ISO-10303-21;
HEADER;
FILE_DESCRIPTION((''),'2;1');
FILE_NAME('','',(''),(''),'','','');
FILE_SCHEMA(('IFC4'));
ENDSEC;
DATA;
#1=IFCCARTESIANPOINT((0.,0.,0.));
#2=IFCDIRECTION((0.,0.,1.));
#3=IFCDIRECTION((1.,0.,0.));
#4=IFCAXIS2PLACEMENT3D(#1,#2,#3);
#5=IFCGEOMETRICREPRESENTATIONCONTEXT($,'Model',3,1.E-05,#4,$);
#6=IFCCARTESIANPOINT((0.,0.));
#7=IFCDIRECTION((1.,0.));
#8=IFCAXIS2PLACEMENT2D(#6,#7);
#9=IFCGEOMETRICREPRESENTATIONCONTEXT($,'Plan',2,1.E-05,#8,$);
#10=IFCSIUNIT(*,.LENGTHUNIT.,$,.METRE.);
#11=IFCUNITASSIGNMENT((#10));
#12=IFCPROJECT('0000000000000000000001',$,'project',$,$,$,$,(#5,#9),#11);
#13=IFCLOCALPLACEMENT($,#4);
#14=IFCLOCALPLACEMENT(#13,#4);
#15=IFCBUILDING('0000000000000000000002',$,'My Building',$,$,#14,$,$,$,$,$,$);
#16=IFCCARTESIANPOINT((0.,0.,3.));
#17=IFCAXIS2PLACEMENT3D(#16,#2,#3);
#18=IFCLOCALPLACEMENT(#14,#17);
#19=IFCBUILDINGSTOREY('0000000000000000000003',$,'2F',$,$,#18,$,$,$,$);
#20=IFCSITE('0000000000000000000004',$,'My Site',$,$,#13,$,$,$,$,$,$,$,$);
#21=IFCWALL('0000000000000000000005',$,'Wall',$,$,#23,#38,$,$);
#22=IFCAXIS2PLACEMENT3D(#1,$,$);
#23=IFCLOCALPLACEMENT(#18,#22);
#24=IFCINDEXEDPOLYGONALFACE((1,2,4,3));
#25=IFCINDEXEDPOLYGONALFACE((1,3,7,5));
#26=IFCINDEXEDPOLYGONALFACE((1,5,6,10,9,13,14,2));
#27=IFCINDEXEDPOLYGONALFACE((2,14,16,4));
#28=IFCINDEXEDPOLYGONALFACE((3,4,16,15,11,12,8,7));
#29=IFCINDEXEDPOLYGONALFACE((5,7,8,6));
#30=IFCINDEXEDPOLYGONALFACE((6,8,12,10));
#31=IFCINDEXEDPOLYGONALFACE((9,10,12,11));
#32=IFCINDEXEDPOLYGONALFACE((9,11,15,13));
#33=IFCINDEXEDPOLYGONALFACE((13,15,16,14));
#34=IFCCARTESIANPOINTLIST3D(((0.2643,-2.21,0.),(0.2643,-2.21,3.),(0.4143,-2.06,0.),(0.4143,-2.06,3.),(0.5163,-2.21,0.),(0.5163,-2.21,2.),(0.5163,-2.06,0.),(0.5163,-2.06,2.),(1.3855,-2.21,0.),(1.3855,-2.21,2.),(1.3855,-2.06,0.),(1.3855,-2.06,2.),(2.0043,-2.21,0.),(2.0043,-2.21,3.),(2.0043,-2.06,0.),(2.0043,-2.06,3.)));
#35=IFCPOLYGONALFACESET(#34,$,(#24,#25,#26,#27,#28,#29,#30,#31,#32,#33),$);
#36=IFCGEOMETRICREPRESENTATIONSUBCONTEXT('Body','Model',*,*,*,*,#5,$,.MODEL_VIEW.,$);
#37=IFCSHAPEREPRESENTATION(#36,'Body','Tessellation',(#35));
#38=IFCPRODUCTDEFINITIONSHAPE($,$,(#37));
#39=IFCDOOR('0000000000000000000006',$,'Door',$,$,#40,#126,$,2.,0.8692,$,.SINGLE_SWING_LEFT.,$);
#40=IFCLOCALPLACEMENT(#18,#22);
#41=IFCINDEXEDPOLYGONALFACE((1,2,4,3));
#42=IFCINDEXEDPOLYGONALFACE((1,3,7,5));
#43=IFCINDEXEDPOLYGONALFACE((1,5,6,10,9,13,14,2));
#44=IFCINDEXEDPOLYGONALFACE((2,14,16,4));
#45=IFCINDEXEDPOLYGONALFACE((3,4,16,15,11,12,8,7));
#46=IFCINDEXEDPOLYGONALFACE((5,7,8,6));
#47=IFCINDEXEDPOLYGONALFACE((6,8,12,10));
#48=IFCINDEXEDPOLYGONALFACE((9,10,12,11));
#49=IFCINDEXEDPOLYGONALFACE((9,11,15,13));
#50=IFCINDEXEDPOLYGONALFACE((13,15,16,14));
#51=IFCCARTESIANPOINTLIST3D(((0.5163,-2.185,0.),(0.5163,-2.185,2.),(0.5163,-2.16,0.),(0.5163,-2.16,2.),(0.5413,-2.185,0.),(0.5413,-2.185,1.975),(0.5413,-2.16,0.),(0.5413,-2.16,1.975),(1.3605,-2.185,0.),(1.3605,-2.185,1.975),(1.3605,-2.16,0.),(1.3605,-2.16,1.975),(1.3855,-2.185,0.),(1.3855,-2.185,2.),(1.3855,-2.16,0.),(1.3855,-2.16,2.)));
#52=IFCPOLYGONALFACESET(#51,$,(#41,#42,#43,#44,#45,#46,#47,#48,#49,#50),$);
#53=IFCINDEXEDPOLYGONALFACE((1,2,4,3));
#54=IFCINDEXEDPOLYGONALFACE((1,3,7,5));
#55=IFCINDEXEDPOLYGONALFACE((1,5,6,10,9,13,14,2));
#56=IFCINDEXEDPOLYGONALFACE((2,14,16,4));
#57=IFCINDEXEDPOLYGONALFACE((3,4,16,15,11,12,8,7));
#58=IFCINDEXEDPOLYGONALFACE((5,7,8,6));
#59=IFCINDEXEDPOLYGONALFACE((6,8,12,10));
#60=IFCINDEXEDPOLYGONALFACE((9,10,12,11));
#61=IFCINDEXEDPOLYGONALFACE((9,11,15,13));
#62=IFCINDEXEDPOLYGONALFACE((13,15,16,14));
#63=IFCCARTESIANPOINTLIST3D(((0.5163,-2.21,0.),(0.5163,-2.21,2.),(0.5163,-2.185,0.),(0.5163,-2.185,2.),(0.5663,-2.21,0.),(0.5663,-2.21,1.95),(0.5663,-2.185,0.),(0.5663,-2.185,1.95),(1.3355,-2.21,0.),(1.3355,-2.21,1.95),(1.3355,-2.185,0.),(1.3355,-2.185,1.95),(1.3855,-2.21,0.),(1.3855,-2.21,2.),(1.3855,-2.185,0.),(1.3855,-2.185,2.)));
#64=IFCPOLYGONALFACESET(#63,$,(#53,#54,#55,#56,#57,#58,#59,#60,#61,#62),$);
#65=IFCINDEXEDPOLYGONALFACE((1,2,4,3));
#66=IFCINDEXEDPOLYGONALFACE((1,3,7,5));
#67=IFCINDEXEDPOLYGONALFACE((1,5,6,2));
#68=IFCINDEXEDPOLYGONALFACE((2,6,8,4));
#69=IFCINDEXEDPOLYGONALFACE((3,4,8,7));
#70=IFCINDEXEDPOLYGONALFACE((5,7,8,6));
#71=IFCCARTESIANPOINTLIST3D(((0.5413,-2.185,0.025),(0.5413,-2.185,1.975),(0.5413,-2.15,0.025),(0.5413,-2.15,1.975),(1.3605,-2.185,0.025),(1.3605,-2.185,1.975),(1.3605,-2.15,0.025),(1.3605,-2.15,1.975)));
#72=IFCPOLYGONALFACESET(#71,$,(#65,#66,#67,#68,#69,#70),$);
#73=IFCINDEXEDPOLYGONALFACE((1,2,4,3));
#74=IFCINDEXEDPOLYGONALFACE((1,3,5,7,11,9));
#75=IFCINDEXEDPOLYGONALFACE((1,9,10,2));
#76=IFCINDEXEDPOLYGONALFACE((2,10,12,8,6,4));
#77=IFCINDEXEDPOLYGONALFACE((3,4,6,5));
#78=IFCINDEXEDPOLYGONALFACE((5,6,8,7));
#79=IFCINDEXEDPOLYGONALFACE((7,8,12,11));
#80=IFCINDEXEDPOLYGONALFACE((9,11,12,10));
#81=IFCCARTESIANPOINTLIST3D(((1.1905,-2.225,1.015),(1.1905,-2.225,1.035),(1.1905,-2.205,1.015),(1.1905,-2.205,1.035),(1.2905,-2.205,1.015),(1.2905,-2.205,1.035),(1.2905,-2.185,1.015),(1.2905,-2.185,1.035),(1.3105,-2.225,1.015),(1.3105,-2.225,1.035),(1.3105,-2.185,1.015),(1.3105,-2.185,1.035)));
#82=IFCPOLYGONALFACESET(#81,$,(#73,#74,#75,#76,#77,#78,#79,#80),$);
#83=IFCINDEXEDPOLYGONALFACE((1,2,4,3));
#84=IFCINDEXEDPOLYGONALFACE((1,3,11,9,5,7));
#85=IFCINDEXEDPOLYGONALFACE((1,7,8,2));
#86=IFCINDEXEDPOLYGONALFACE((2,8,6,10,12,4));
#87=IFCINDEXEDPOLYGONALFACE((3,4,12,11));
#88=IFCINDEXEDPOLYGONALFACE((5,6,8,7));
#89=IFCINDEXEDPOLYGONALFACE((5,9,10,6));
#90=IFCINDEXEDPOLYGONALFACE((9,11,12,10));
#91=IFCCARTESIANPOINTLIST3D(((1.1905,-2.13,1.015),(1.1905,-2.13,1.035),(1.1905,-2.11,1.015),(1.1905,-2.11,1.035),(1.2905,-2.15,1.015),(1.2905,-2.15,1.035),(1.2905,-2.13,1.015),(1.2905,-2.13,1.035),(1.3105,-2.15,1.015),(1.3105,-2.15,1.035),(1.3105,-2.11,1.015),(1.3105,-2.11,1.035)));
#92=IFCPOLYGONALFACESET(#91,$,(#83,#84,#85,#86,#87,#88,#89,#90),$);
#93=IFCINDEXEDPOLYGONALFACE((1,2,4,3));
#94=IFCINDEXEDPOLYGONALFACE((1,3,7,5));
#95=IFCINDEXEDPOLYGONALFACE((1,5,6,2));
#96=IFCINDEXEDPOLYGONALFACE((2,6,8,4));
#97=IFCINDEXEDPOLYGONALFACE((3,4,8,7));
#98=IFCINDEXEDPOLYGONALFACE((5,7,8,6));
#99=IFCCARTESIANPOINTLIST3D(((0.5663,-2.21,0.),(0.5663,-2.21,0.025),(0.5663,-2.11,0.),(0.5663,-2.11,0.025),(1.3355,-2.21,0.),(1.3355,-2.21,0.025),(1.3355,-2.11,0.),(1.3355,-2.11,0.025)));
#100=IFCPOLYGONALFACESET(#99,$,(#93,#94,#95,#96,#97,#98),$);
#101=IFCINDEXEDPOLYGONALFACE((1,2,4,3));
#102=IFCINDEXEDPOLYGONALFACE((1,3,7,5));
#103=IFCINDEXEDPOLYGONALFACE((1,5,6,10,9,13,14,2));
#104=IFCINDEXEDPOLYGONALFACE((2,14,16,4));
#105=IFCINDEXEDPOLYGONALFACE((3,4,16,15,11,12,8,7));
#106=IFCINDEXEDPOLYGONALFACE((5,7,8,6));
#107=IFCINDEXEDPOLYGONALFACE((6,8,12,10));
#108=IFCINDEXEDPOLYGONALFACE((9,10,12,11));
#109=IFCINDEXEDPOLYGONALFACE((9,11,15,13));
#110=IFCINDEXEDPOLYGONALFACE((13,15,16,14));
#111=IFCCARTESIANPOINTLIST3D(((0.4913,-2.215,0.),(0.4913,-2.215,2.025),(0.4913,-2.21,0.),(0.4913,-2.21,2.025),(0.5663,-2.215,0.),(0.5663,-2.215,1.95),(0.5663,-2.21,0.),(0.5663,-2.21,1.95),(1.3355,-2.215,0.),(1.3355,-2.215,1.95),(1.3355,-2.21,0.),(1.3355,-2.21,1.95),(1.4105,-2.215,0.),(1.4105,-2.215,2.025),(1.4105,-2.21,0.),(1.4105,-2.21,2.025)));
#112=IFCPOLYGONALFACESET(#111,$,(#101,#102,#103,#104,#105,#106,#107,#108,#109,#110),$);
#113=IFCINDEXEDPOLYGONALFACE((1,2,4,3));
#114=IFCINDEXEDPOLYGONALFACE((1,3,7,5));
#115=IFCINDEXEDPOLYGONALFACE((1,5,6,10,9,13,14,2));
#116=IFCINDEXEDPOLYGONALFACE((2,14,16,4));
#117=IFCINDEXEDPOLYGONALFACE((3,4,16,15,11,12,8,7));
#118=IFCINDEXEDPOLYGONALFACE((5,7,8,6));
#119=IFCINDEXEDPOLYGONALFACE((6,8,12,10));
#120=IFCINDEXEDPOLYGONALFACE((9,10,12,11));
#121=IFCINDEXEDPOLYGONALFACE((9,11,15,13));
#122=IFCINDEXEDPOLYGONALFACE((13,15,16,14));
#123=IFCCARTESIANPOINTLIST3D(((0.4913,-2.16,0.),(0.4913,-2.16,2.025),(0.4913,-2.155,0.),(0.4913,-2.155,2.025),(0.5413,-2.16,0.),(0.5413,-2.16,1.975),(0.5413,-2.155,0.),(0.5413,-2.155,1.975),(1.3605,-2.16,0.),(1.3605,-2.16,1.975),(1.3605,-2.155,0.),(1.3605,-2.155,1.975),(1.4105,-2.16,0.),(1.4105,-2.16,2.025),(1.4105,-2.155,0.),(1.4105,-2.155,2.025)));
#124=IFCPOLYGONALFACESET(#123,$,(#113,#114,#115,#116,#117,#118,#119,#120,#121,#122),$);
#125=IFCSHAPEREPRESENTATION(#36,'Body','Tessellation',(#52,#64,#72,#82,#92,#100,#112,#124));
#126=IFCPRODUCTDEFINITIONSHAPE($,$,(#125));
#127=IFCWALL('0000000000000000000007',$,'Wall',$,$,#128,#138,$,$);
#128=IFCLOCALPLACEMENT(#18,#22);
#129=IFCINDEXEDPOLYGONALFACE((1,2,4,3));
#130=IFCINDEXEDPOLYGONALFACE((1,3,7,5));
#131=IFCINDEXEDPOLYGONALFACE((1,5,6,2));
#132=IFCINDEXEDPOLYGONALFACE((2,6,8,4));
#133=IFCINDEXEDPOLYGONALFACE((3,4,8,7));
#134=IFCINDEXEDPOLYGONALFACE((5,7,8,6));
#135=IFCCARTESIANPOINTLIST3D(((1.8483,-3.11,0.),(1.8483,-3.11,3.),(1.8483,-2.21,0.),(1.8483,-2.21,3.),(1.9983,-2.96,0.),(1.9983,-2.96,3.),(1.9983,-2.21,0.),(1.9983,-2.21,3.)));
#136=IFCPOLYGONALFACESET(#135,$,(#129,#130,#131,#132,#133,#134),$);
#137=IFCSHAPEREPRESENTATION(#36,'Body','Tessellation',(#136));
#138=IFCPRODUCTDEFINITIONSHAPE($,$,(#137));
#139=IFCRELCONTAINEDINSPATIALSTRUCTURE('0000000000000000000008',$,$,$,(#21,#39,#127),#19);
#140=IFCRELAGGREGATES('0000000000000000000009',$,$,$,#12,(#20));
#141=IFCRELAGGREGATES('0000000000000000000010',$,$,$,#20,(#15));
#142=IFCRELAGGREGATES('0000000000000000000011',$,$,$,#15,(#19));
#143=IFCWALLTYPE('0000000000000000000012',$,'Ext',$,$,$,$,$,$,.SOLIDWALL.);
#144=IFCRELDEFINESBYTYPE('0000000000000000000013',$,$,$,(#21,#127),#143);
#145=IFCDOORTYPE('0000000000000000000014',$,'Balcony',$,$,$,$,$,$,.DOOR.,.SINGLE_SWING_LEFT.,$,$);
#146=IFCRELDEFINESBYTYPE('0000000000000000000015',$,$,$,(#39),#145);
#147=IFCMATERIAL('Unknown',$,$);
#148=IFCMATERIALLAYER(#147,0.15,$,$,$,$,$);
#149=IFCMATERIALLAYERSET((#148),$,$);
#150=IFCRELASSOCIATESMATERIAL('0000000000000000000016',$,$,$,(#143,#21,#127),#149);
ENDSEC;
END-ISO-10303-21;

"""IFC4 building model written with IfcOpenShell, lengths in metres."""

from ifc_helpers import new_model, entity, si_unit, frame, origin_with_axes, origin_2d_with_axis, place, context, subcontext, project, spatial, line, indexed_curve, outline, extrude, shape, source, transform, mapped, material, layer, layer_set, layer_usage, type_object, type_shapes, element, fill, save


model = new_model("IFC4")

# Units and contexts
model_context = context("Model", 3, precision=1e-05, world=origin_with_axes())
plan_context = context("Plan", 2, precision=1e-05, world=origin_2d_with_axis())
body_context_1 = subcontext(model_context, "Body", "Model", "MODEL_VIEW")
body_context_2 = subcontext(plan_context, "Body", "Plan", "PLAN_VIEW")
ifc_project = project(units=[si_unit("LENGTHUNIT", "METRE")], contexts=[model_context, plan_context])

# Site, building, storey
site_placement = place(None, origin_with_axes())
site = spatial("IfcSite", under=ifc_project, at=site_placement, Name="My Site")
building_placement = place(site_placement, origin_with_axes())
building = spatial("IfcBuilding", under=site, at=building_placement, Name="My Building")
storey_placement = place(building_placement, frame((0.0, 0.0, 3.0), z_axis=(0.0, 0.0, 1.0), x_axis=(1.0, 0.0, 0.0)))
storey = spatial("IfcBuildingStorey", under=building, at=storey_placement, Name="2F")

# Wall, opening, door
ifc_material = material(Name="Unknown")
ifc_layer_1 = layer(ifc_material, 0.15)
ifc_layer_set_1 = layer_set([ifc_layer_1])
ifc_layer_usage_1 = layer_usage(ifc_layer_set_1, "AXIS2", "POSITIVE", 0.0)
wall_type_1 = type_object("IfcWallType", Name="Ext", PredefinedType="SOLIDWALL", material=ifc_layer_set_1)
wall_1_placement = place(storey_placement, frame((0.2643, -2.21, 0.0), z_axis=(0.0, 0.0, 1.0), x_axis=(1.0, 0.0, 0.0)))
wall_1 = element("IfcWall", 1, at=wall_1_placement, inside=storey, type_object=wall_type_1, material=ifc_layer_usage_1, Name="Wall", context=body_context_1, shape_type="SweptSolid", body=[
    extrude(outline(indexed_curve([(0.0, 0.0), (0.15, 0.15), (1.74, 0.15), (1.74, 0.0)], segments=[line(1, 2, 3, 4, 1)])), origin_with_axes(), (0.0, 0.0, 1.0), 3.0),
])
shared_shape_1 = source(origin_with_axes(), body_context_1, "Body", "SweptSolid", [
    extrude(outline(indexed_curve([(0.0, 0.0), (0.8692, 0.0), (0.8692, 2.0), (0.0, 2.0)], segments=[line(1, 2, 3, 4, 1)])), frame((0.0, -0.6, 0.0), z_axis=(0.0, -1.0, 0.0), x_axis=(1.0, 0.0, 0.0)), (0.0, 0.0, -1.0), 1.2),
])
opening_1_placement = place(wall_1_placement, frame((0.252, 0.0, 0.0), z_axis=(0.0, 0.0, 1.0), x_axis=(1.0, 0.0, 0.0)))
opening_1 = element("IfcOpeningElement", 2, at=opening_1_placement, cuts=wall_1, PredefinedType="OPENING", context=body_context_1, shape_type="MappedRepresentation", body=[
    mapped(shared_shape_1, transform((0.0, 0.0, 0.0), x_axis=(1.0, 0.0, 0.0), y_axis=(0.0, 1.0, 0.0), z_axis=(0.0, 0.0, 1.0), scale=1.0)),
])
door_type_1 = type_object("IfcDoorType", Name="Balcony", OperationType="SINGLE_SWING_LEFT", PredefinedType="DOOR")
shared_shape_2 = source(origin_with_axes(), body_context_1, "Body", "SweptSolid", [
    extrude(outline(indexed_curve([(0.0, 0.0), (0.0, 2.0), (0.8692, 2.0), (0.8692, 0.0), (0.8442, 0.0), (0.8442, 1.975), (0.025, 1.975), (0.025, 0.0)], segments=[line(1, 2, 3, 4, 5, 6, 7, 8, 1)])), frame((0.0, 0.025, 0.0), z_axis=(0.0, -1.0, 0.0), x_axis=(1.0, 0.0, 0.0)), (0.0, 0.0, -1.0), 0.025),
    extrude(outline(indexed_curve([(0.0, 0.0), (0.0, 2.0), (0.8692, 2.0), (0.8692, 0.0), (0.8192, 0.0), (0.8192, 1.95), (0.05, 1.95), (0.05, 0.0)], segments=[line(1, 2, 3, 4, 5, 6, 7, 8, 1)])), frame((0.0, 0.0, 0.0), z_axis=(0.0, -1.0, 0.0), x_axis=(1.0, 0.0, 0.0)), (0.0, 0.0, -1.0), 0.025),
    extrude(outline(indexed_curve([(0.0, 0.0), (0.8192, 0.0), (0.8192, 0.035), (0.0, 0.035)], segments=[line(1, 2, 3, 4, 1)])), frame((0.025, 0.025, 0.025), z_axis=(0.0, 0.0, 1.0), x_axis=(1.0, 0.0, 0.0)), (0.0, 0.0, 1.0), 1.95),
    extrude(outline(indexed_curve([(0.0, 0.0), (0.0, -0.04), (-0.12, -0.04), (-0.12, -0.02), (-0.02, -0.02), (-0.02, 0.0)], segments=[line(1, 2, 3, 4, 5, 6, 1)])), frame((0.7942, 0.025, 1.015), z_axis=(0.0, 0.0, 1.0), x_axis=(1.0, 0.0, 0.0)), (0.0, 0.0, 1.0), 0.02),
    extrude(outline(indexed_curve([(0.0, 0.0), (0.0, 0.04), (-0.12, 0.04), (-0.12, 0.02), (-0.02, 0.02), (-0.02, 0.0)], segments=[line(1, 2, 3, 4, 5, 6, 1)])), frame((0.7942, 0.06, 1.015), z_axis=(0.0, 0.0, 1.0), x_axis=(1.0, 0.0, 0.0)), (0.0, 0.0, 1.0), 0.02),
    extrude(outline(indexed_curve([(0.0, 0.0), (0.7692, 0.0), (0.7692, 0.1), (0.0, 0.1)], segments=[line(1, 2, 3, 4, 1)])), frame((0.05, 0.0, 0.0), z_axis=(0.0, 0.0, 1.0), x_axis=(1.0, 0.0, 0.0)), (0.0, 0.0, 1.0), 0.025),
    extrude(outline(indexed_curve([(0.0, 0.0), (0.0, 2.025), (0.9192, 2.025), (0.9192, 0.0), (0.8442, 0.0), (0.8442, 1.95), (0.075, 1.95), (0.075, 0.0)], segments=[line(1, 2, 3, 4, 5, 6, 7, 8, 1)])), frame((-0.025, -0.005, 0.0), z_axis=(0.0, -1.0, 0.0), x_axis=(1.0, 0.0, 0.0)), (0.0, 0.0, -1.0), 0.005),
    extrude(outline(indexed_curve([(0.0, 0.0), (0.0, 2.025), (0.9192, 2.025), (0.9192, 0.0), (0.8692, 0.0), (0.8692, 1.975), (0.05, 1.975), (0.05, 0.0)], segments=[line(1, 2, 3, 4, 5, 6, 7, 8, 1)])), frame((-0.025, 0.05, 0.0), z_axis=(0.0, -1.0, 0.0), x_axis=(1.0, 0.0, 0.0)), (0.0, 0.0, -1.0), 0.005),
])
shared_shape_3 = source(origin_with_axes(), body_context_2, "Body", "Curve2D", [
    entity("IfcIndexedPolyCurve", entity("IfcCartesianPointList2D", [[0.0, 0.0], [0.0, 0.05], [0.025, 0.05], [0.025, 0.025], [0.05, 0.025], [0.05, 0.0]]), [entity("IfcLineIndex", [1, 2, 3, 4, 5, 6, 1])]),
    entity("IfcIndexedPolyCurve", entity("IfcCartesianPointList2D", [[0.8692, 0.0], [0.8692, 0.05], [0.8442, 0.05], [0.8442, 0.025], [0.8192, 0.025], [0.8192, 0.0]]), [entity("IfcLineIndex", [1, 2, 3, 4, 5, 6, 1])]),
    entity("IfcTrimmedCurve", entity("IfcEllipse", entity("IfcAxis2Placement2D", entity("IfcCartesianPoint", [0.06, 0.05]), entity("IfcDirection", [1.0, 0.0])), 0.7842, 0.8192), [entity("IfcCartesianPoint", [0.8442, 0.05])], [entity("IfcCartesianPoint", [0.06, 0.8692])], True, "CARTESIAN"),
    entity("IfcIndexedPolyCurve", entity("IfcCartesianPointList2D", [[0.025, 0.05], [0.06, 0.05], [0.06, 0.8692], [0.025, 0.8692]]), [entity("IfcLineIndex", [1, 2, 3, 4, 1])]),
])
type_shapes(door_type_1, [shared_shape_2, shared_shape_3])
door_1_placement = place(opening_1_placement, frame((0.0, 0.0, 0.0), z_axis=(0.0, 0.0, 1.0), x_axis=(1.0, 0.0, 0.0)))
door_1 = element("IfcDoor", 3, at=door_1_placement, inside=storey, type_object=door_type_1, Name="Door", OperationType="SINGLE_SWING_LEFT", OverallHeight=2.0, OverallWidth=0.8692, shapes=[
    shape(body_context_1, "Body", "MappedRepresentation", [mapped(shared_shape_2, transform((0.0, 0.0, 0.0), x_axis=(1.0, 0.0, 0.0), y_axis=(0.0, 1.0, 0.0), z_axis=(0.0, 0.0, 1.0), scale=1.0))]),
    shape(body_context_2, "Body", "MappedRepresentation", [mapped(shared_shape_3, transform((0.0, 0.0, 0.0), x_axis=(1.0, 0.0, 0.0), y_axis=(0.0, 1.0, 0.0), z_axis=(0.0, 0.0, 1.0), scale=1.0))]),
])
fill(opening_1, door_1)

# Wall
ifc_layer_usage_2 = layer_usage(ifc_layer_set_1, "AXIS2", "POSITIVE", 0.0)
wall_2_placement = place(storey_placement, frame((1.8483, -2.21, 0.0), z_axis=(0.0, 0.0, 1.0), x_axis=(0.0, -1.0, 0.0)))
element("IfcWall", 4, at=wall_2_placement, inside=storey, type_object=wall_type_1, material=ifc_layer_usage_2, Name="Wall", context=body_context_1, shape_type="SweptSolid", body=[
    extrude(outline(indexed_curve([(0.0, 0.0), (0.0, 0.15), (0.75, 0.15), (0.9, 0.0)], segments=[line(1, 2, 3, 4, 1)])), origin_with_axes(), (0.0, 0.0, 1.0), 3.0),
])

save(model, "model.ifc")
